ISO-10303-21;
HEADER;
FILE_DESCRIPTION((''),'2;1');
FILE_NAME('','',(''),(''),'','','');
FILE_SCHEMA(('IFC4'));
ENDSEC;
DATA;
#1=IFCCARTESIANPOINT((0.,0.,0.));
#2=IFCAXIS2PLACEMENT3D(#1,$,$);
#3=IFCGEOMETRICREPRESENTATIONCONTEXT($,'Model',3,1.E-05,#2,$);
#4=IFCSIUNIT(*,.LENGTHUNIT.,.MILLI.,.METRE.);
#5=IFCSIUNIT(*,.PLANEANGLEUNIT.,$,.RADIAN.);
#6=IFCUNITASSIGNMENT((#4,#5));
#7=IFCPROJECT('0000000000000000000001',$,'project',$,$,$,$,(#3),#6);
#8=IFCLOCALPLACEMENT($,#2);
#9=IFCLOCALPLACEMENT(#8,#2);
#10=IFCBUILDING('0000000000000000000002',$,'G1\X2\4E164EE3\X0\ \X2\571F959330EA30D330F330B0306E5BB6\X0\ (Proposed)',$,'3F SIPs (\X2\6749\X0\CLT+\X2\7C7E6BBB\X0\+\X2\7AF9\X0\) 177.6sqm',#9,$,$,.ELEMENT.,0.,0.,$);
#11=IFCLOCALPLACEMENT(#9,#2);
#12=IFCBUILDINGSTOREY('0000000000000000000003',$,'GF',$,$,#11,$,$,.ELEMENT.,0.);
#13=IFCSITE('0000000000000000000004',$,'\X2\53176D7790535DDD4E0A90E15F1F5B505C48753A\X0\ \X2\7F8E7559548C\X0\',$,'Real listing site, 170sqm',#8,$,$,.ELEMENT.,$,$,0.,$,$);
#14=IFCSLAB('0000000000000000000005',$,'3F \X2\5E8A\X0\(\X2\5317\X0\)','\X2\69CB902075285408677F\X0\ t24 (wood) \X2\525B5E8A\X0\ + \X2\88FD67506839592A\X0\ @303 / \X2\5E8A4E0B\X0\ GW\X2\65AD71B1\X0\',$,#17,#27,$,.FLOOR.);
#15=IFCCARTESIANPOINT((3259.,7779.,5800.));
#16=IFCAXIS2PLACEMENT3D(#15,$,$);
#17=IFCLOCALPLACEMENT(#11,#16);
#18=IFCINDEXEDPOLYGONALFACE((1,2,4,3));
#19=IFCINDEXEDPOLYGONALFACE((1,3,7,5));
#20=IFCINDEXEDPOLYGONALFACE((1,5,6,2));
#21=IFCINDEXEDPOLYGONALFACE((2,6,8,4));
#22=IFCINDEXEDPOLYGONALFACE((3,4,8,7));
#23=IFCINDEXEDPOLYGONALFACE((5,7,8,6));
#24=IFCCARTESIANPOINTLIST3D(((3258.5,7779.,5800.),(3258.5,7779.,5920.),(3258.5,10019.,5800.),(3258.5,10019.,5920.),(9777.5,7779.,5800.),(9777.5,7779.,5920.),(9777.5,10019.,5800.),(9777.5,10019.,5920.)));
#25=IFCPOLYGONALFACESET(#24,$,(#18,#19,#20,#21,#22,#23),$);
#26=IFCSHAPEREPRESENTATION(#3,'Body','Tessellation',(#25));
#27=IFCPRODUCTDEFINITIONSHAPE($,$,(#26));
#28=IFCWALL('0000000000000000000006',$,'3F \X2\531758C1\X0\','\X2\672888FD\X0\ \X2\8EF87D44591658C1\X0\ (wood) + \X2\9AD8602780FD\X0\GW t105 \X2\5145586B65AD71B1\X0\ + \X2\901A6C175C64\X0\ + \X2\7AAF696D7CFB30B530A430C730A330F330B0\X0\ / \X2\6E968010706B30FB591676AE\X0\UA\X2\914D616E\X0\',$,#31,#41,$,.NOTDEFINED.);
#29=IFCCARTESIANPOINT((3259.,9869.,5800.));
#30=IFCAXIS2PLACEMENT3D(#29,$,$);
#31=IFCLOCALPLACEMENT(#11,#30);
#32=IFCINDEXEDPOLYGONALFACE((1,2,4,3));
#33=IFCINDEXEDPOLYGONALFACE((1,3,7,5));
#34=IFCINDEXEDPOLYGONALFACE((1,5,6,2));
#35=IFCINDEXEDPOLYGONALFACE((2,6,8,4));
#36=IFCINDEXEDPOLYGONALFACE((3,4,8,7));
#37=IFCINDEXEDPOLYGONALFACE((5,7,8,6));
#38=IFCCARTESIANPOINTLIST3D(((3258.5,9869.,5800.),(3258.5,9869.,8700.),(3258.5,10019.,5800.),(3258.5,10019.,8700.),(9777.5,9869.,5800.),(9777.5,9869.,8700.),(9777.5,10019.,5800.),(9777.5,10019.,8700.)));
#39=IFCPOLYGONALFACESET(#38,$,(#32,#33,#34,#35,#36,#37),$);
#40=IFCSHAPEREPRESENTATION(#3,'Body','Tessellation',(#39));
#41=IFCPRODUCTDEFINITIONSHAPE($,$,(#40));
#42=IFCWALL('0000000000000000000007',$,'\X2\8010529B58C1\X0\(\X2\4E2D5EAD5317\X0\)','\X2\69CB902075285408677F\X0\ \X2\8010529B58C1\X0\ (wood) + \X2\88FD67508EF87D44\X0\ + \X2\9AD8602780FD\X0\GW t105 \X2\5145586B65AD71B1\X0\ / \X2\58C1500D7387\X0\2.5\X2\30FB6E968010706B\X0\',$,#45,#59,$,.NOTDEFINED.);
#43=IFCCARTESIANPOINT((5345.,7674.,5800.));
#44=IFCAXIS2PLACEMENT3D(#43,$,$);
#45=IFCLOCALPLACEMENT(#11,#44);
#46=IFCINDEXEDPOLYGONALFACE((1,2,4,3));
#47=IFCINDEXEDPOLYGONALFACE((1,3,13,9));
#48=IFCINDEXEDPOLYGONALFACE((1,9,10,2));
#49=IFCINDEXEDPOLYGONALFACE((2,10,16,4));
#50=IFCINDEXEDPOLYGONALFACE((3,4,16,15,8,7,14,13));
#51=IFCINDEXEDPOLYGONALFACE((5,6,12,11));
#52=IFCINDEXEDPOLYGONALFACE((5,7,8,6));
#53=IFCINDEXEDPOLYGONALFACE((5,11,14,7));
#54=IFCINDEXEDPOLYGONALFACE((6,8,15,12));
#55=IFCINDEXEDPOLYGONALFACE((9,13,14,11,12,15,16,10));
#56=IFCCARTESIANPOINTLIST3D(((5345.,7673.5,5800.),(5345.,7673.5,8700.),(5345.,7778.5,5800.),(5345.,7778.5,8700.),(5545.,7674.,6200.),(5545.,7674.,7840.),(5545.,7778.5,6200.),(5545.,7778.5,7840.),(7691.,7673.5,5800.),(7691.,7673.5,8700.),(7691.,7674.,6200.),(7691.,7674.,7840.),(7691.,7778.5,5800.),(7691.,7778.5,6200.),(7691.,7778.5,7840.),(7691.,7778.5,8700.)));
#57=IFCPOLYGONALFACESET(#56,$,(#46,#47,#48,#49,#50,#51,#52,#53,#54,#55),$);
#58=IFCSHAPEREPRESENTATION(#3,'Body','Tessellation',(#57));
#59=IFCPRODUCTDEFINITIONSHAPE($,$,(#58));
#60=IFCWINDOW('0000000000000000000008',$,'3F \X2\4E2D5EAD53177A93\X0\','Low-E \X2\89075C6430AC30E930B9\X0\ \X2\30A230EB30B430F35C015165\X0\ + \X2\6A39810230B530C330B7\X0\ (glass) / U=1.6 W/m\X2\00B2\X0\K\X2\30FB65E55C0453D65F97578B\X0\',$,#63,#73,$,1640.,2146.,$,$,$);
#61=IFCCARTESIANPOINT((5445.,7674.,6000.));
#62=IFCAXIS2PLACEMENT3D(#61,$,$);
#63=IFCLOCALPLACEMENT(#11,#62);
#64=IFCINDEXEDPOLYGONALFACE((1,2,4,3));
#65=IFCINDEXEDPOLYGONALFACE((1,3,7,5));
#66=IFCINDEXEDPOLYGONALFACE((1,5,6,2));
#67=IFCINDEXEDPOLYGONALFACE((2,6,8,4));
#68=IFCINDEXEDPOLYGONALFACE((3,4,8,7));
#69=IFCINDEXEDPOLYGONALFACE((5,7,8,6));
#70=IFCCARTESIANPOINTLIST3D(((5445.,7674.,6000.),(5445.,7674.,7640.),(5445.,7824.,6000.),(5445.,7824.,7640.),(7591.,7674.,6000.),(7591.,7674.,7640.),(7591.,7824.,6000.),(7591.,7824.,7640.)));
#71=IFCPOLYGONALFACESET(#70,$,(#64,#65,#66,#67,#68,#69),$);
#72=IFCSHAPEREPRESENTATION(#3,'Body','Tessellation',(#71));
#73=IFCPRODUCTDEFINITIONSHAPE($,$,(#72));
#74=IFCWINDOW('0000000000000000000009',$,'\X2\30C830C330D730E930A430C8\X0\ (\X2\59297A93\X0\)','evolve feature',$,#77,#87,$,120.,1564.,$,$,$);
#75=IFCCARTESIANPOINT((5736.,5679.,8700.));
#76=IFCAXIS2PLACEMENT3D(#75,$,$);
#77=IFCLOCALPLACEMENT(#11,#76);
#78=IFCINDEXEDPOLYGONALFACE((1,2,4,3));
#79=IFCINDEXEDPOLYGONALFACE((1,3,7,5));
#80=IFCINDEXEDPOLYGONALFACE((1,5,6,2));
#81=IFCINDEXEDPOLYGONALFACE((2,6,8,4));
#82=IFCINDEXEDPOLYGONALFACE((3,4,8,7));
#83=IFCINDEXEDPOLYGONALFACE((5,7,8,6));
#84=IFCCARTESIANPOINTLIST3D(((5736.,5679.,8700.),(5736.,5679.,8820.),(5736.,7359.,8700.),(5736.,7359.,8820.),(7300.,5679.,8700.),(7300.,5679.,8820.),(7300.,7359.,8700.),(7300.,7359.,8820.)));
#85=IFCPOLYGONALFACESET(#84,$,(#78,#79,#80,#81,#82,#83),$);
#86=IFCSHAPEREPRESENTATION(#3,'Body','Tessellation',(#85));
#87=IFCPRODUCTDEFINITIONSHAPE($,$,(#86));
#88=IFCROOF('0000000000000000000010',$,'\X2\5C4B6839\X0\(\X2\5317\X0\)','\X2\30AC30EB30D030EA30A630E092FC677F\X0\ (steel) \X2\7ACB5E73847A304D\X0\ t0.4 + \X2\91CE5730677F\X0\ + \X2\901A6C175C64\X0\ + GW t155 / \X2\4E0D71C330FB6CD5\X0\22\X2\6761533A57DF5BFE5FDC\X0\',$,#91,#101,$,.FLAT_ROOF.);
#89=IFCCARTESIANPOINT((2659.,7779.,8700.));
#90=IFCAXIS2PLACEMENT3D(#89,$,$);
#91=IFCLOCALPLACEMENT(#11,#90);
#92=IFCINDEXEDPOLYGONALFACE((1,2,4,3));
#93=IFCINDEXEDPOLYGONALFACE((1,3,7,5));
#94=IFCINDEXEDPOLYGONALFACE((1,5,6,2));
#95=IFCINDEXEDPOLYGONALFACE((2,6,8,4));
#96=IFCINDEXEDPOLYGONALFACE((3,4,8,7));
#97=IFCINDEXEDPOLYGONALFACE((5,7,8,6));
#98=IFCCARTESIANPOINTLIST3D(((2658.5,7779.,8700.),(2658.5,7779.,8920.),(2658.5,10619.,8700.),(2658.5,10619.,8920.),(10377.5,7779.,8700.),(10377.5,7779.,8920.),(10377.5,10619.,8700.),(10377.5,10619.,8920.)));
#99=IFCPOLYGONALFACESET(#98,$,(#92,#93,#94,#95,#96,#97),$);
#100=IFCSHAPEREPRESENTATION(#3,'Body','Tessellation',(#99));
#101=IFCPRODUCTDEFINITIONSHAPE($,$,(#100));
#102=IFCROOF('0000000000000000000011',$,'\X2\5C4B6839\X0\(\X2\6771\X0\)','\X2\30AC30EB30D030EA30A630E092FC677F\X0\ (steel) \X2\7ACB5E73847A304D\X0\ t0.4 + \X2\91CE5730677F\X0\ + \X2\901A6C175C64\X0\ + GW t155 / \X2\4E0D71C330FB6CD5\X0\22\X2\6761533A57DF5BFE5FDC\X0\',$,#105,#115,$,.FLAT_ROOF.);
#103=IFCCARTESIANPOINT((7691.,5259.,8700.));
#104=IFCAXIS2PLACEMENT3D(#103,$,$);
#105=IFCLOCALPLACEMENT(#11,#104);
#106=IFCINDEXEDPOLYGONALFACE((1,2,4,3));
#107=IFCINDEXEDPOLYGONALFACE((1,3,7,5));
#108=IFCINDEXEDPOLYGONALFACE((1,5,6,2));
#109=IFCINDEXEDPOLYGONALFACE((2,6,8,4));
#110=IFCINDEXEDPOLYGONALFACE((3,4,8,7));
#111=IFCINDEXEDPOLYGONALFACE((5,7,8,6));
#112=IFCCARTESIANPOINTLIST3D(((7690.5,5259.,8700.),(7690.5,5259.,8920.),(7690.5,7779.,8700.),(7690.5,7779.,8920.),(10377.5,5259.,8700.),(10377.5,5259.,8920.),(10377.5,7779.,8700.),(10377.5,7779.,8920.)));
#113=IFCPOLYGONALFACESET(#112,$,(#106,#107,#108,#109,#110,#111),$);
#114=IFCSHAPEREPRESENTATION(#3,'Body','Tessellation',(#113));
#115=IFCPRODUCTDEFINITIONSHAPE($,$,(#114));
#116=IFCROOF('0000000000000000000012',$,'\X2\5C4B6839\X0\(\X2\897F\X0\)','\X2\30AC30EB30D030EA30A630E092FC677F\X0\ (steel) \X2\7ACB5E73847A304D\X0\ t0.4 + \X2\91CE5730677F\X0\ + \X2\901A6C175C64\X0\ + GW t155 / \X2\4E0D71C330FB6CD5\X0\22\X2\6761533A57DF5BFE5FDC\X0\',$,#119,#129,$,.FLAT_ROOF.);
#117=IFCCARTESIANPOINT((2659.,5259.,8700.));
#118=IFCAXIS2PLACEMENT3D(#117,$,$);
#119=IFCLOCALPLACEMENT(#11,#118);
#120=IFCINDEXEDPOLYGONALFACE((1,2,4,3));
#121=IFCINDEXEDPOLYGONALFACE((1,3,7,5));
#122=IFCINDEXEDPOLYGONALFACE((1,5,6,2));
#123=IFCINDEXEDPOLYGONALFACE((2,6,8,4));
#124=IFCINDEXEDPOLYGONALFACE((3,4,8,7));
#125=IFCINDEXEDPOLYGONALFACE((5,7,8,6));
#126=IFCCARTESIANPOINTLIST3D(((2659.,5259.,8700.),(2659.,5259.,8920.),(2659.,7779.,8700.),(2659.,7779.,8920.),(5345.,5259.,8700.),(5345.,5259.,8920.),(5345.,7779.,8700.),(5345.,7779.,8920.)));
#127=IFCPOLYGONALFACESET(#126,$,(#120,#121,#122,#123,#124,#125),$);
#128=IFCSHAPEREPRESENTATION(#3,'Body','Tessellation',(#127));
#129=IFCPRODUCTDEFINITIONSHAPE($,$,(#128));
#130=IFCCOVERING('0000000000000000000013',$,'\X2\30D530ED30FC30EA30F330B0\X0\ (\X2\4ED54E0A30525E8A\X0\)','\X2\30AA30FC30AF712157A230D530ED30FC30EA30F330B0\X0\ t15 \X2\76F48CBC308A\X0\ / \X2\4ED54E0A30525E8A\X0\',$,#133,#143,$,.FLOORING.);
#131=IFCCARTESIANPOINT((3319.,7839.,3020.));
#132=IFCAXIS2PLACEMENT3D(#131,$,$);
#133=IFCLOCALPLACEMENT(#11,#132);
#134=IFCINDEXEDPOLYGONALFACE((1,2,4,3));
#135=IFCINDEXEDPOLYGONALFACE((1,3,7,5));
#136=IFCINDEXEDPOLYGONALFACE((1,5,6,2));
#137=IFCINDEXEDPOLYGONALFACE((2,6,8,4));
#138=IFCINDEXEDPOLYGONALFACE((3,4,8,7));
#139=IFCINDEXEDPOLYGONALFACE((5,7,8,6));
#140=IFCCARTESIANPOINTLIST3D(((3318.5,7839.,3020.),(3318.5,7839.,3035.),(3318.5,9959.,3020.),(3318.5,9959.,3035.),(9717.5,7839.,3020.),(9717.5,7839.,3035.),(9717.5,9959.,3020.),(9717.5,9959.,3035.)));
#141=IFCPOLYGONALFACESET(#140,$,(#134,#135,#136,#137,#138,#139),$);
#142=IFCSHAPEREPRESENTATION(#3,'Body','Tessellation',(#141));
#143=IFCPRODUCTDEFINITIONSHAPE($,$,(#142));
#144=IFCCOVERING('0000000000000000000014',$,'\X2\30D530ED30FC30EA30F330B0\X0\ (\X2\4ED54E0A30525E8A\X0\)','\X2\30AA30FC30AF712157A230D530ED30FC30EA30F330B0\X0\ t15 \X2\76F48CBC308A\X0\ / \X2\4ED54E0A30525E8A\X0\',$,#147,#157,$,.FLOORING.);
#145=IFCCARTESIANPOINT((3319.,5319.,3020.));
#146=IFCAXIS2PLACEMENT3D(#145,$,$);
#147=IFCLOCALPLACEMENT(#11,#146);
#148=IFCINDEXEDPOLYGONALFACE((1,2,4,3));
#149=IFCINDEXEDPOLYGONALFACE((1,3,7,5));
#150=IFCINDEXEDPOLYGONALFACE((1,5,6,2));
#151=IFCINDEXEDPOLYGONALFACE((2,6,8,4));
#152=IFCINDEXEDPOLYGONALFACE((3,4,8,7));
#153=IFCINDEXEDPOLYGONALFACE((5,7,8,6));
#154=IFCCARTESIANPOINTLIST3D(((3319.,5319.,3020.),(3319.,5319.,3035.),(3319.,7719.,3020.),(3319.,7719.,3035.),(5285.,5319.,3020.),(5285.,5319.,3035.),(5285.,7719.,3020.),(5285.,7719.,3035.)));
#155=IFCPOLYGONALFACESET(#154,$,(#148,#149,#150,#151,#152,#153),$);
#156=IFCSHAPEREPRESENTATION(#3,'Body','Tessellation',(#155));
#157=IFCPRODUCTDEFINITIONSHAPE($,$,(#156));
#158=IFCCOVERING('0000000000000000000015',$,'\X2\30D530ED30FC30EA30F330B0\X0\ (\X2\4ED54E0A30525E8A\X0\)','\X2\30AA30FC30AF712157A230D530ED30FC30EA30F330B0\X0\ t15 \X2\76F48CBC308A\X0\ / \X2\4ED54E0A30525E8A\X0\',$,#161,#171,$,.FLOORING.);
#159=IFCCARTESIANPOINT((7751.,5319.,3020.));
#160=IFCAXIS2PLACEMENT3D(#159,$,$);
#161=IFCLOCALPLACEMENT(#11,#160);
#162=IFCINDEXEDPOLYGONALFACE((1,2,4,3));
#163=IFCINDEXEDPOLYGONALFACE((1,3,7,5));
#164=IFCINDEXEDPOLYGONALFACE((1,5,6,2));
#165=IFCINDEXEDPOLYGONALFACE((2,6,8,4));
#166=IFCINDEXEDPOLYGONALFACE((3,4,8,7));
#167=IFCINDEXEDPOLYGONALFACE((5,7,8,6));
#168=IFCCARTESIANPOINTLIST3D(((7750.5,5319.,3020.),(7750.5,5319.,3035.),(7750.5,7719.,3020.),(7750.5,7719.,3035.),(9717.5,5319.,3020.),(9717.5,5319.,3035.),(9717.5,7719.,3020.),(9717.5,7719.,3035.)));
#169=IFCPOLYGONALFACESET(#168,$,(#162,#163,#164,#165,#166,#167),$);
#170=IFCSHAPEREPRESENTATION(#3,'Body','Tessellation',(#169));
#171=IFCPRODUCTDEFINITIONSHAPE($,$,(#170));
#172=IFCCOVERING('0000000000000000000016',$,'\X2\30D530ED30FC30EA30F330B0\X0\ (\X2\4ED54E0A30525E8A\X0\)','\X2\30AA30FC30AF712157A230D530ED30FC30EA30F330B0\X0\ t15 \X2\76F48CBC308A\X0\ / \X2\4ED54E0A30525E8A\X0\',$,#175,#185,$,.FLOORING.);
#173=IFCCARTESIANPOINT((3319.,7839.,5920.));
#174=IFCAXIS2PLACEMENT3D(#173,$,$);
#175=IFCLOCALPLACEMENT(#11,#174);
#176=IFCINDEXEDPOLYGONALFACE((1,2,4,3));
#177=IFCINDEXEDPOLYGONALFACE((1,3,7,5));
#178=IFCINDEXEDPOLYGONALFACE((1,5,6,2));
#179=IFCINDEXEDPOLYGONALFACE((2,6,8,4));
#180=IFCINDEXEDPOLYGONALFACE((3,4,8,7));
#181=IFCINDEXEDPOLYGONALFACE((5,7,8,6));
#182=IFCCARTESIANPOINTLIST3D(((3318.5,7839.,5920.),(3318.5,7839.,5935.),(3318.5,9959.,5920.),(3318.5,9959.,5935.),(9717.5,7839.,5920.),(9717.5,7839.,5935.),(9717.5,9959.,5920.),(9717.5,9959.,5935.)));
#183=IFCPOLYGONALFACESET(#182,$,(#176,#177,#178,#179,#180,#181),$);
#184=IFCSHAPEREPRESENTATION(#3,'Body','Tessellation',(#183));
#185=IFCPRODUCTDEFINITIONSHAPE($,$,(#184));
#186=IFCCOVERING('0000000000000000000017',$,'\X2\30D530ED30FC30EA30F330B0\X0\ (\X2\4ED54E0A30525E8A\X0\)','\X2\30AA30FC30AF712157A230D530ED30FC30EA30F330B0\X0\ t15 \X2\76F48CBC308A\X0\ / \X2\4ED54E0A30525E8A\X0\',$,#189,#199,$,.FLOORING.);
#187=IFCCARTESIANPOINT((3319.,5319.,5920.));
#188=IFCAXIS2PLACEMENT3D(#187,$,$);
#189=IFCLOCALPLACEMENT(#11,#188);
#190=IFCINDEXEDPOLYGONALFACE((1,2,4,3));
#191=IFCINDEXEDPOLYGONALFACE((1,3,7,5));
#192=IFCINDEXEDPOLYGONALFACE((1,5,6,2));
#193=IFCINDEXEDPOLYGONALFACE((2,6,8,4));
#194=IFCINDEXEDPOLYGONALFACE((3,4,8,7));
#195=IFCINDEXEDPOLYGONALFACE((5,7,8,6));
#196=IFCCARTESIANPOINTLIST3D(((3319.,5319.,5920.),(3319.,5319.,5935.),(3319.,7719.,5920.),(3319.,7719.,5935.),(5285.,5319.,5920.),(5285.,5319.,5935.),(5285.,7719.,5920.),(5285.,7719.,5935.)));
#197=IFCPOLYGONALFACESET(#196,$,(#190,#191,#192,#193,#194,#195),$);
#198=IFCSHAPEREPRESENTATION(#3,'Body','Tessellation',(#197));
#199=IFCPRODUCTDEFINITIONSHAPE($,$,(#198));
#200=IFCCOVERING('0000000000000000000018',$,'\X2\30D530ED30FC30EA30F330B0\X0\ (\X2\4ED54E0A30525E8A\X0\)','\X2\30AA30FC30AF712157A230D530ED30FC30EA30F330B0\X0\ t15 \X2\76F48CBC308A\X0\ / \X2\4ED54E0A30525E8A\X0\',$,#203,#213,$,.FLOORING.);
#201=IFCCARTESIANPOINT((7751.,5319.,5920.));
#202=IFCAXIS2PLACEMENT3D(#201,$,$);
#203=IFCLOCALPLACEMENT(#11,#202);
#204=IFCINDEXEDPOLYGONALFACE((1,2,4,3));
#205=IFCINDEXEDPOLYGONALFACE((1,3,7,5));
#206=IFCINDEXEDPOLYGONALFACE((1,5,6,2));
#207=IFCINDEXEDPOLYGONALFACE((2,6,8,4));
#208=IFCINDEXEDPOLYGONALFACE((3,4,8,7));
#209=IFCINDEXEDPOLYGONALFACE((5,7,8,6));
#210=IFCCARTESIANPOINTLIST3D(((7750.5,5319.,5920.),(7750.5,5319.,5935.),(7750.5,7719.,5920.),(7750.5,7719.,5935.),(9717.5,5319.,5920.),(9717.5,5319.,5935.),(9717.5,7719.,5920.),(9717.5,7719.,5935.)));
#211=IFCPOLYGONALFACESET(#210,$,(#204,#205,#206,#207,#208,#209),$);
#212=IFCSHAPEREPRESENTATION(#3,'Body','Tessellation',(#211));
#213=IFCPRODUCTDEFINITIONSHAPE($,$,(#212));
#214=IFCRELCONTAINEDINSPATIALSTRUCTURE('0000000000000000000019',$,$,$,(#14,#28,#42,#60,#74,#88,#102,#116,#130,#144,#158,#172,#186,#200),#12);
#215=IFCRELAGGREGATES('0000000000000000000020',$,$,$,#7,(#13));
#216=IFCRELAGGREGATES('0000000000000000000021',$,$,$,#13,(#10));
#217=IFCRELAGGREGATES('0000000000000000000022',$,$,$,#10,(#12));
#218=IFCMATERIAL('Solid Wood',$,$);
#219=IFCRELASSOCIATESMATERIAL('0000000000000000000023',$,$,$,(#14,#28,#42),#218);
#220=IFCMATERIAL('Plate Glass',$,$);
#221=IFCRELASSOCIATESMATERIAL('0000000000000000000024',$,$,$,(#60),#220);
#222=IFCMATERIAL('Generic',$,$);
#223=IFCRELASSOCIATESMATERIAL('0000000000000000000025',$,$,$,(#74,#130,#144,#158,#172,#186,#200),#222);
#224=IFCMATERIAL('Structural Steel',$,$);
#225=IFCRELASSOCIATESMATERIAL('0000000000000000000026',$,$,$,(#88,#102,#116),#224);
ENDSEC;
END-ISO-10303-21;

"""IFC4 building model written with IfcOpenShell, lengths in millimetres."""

from ifc_helpers import new_model, si_unit, frame, frame_2d, origin, place, context, project, spatial, rectangle, extrude, material, element, fill, save


model = new_model("IFC4")

# Units and contexts
model_context = context("Model", 3, precision=1e-05, world=origin())
ifc_project = project(units=[si_unit("LENGTHUNIT", "METRE", prefix="MILLI"), si_unit("PLANEANGLEUNIT", "RADIAN")], contexts=[model_context])

# Site, building, storey
site_placement = place(None, origin())
site = spatial("IfcSite", under=ifc_project, at=site_placement, Name="北海道川上郡弟子屈町 美留和", ObjectType="Real listing site, 170sqm", CompositionType="ELEMENT", RefElevation=0.0)
building_placement = place(site_placement, origin())
building = spatial("IfcBuilding", under=site, at=building_placement, Name="G1世代 土間リビングの家 (Proposed)", ObjectType="3F SIPs (杉CLT+籾殻+竹) 177.6sqm", CompositionType="ELEMENT", ElevationOfRefHeight=0.0, ElevationOfTerrain=0.0)
storey_placement = place(building_placement, origin())
storey = spatial("IfcBuildingStorey", under=building, at=storey_placement, Name="GF", CompositionType="ELEMENT", Elevation=0.0)

# Slab
ifc_material_1 = material(Name="Solid Wood")
slab_placement = place(storey_placement, frame((3259.0, 7779.0, 5800.0)))
element("IfcSlab", 1, at=slab_placement, inside=storey, material=ifc_material_1, Name="3F 床(北)", Description="構造用合板 t24 (wood) 剛床 + 製材根太 @303 / 床下 GW断熱", PredefinedType="FLOOR", context=model_context, shape_type="SweptSolid", body=[
    extrude(rectangle(XDim=6519.0, YDim=2240.0, at=frame_2d((3259.0, 1120.0))), frame((3259.0, 7779.0, 5800.0)), (0.0, 0.0, 1.0), 120.0),
])

# Wall
wall_1_placement = place(storey_placement, frame((3259.0, 9869.0, 5800.0)))
element("IfcWall", 2, at=wall_1_placement, inside=storey, material=ifc_material_1, Name="3F 北壁", Description="木製 軸組外壁 (wood) + 高性能GW t105 充填断熱 + 通気層 + 窯業系サイディング / 準耐火・外皮UA配慮", PredefinedType="NOTDEFINED", context=model_context, shape_type="SweptSolid", body=[
    extrude(rectangle(XDim=6519.0, YDim=150.0, at=frame_2d((3259.0, 75.0))), frame((3259.0, 9869.0, 5800.0)), (0.0, 0.0, 1.0), 2900.0),
])

# Wall, opening, window
wall_2_placement = place(storey_placement, frame((5345.0, 7674.0, 5800.0)))
wall_2 = element("IfcWall", 3, at=wall_2_placement, inside=storey, material=ifc_material_1, Name="耐力壁(中庭北)", Description="構造用合板 耐力壁 (wood) + 製材軸組 + 高性能GW t105 充填断熱 / 壁倍率2.5・準耐火", PredefinedType="NOTDEFINED", context=model_context, shape_type="SweptSolid", body=[
    extrude(rectangle(XDim=2346.0, YDim=105.0, at=frame_2d((1173.0, 52.0))), frame((5345.0, 7674.0, 5800.0)), (0.0, 0.0, 1.0), 2900.0),
])
opening_placement = place(storey_placement, frame((5445.0, 7674.0, 6000.0)))
opening = element("IfcOpeningElement", 4, at=opening_placement, cuts=wall_2, PredefinedType="NOTDEFINED", context=model_context, shape_type="SweptSolid", body=[
    extrude(rectangle(XDim=2146.0, YDim=150.0, at=frame_2d((1073.0, 75.0))), frame((5445.0, 7674.0, 6000.0)), (0.0, 0.0, 1.0), 1640.0),
])
ifc_material_2 = material(Name="Plate Glass")
window_1_placement = place(storey_placement, frame((5445.0, 7674.0, 6000.0)))
window_1 = element("IfcWindow", 5, at=window_1_placement, inside=storey, material=ifc_material_2, Name="3F 中庭北窓", Description="Low-E 複層ガラス アルゴン封入 + 樹脂サッシ (glass) / U=1.6 W/m²K・日射取得型", OverallHeight=1640.0, OverallWidth=2146.0, context=model_context, shape_type="SweptSolid", body=[
    extrude(rectangle(XDim=2146.0, YDim=150.0, at=frame_2d((1073.0, 75.0))), frame((5445.0, 7674.0, 6000.0)), (0.0, 0.0, 1.0), 1640.0),
])
fill(opening, window_1)

# Window
ifc_material_3 = material(Name="Generic")
window_2_placement = place(storey_placement, frame((5736.0, 5679.0, 8700.0)))
element("IfcWindow", 6, at=window_2_placement, inside=storey, material=ifc_material_3, Name="トップライト (天窓)", Description="evolve feature", OverallHeight=120.0, OverallWidth=1564.0, context=model_context, shape_type="SweptSolid", body=[
    extrude(rectangle(XDim=1564.0, YDim=1680.0, at=frame_2d((782.0, 840.0))), frame((5736.0, 5679.0, 8700.0)), (0.0, 0.0, 1.0), 120.0),
])

# Roofs
ifc_material_4 = material(Name="Structural Steel")
roof_1_placement = place(storey_placement, frame((2659.0, 7779.0, 8700.0)))
element("IfcRoof", 7, at=roof_1_placement, inside=storey, material=ifc_material_4, Name="屋根(北)", Description="ガルバリウム鋼板 (steel) 立平葺き t0.4 + 野地板 + 通気層 + GW t155 / 不燃・法22条区域対応", PredefinedType="FLAT_ROOF", context=model_context, shape_type="SweptSolid", body=[
    extrude(rectangle(XDim=7719.0, YDim=2840.0, at=frame_2d((3859.0, 1420.0))), frame((2659.0, 7779.0, 8700.0)), (0.0, 0.0, 1.0), 220.0),
])
roof_2_placement = place(storey_placement, frame((7691.0, 5259.0, 8700.0)))
element("IfcRoof", 8, at=roof_2_placement, inside=storey, material=ifc_material_4, Name="屋根(東)", Description="ガルバリウム鋼板 (steel) 立平葺き t0.4 + 野地板 + 通気層 + GW t155 / 不燃・法22条区域対応", PredefinedType="FLAT_ROOF", context=model_context, shape_type="SweptSolid", body=[
    extrude(rectangle(XDim=2687.0, YDim=2520.0, at=frame_2d((1343.0, 1260.0))), frame((7691.0, 5259.0, 8700.0)), (0.0, 0.0, 1.0), 220.0),
])
roof_3_placement = place(storey_placement, frame((2659.0, 5259.0, 8700.0)))
element("IfcRoof", 9, at=roof_3_placement, inside=storey, material=ifc_material_4, Name="屋根(西)", Description="ガルバリウム鋼板 (steel) 立平葺き t0.4 + 野地板 + 通気層 + GW t155 / 不燃・法22条区域対応", PredefinedType="FLAT_ROOF", context=model_context, shape_type="SweptSolid", body=[
    extrude(rectangle(XDim=2686.0, YDim=2520.0, at=frame_2d((1343.0, 1260.0))), frame((2659.0, 5259.0, 8700.0)), (0.0, 0.0, 1.0), 220.0),
])

# Coverings
covering_1_placement = place(storey_placement, frame((3319.0, 7839.0, 3020.0)))
element("IfcCovering", 10, at=covering_1_placement, inside=storey, material=ifc_material_3, Name="フローリング (仕上げ床)", Description="オーク無垢フローリング t15 直貼り / 仕上げ床", PredefinedType="FLOORING", context=model_context, shape_type="SweptSolid", body=[
    extrude(rectangle(XDim=6399.0, YDim=2120.0, at=frame_2d((3199.0, 1060.0))), frame((3319.0, 7839.0, 3020.0)), (0.0, 0.0, 1.0), 15.0),
])
covering_2_placement = place(storey_placement, frame((3319.0, 5319.0, 3020.0)))
element("IfcCovering", 11, at=covering_2_placement, inside=storey, material=ifc_material_3, Name="フローリング (仕上げ床)", Description="オーク無垢フローリング t15 直貼り / 仕上げ床", PredefinedType="FLOORING", context=model_context, shape_type="SweptSolid", body=[
    extrude(rectangle(XDim=1966.0, YDim=2400.0, at=frame_2d((983.0, 1200.0))), frame((3319.0, 5319.0, 3020.0)), (0.0, 0.0, 1.0), 15.0),
])
covering_3_placement = place(storey_placement, frame((7751.0, 5319.0, 3020.0)))
element("IfcCovering", 12, at=covering_3_placement, inside=storey, material=ifc_material_3, Name="フローリング (仕上げ床)", Description="オーク無垢フローリング t15 直貼り / 仕上げ床", PredefinedType="FLOORING", context=model_context, shape_type="SweptSolid", body=[
    extrude(rectangle(XDim=1967.0, YDim=2400.0, at=frame_2d((983.0, 1200.0))), frame((7751.0, 5319.0, 3020.0)), (0.0, 0.0, 1.0), 15.0),
])
covering_4_placement = place(storey_placement, frame((3319.0, 7839.0, 5920.0)))
element("IfcCovering", 13, at=covering_4_placement, inside=storey, material=ifc_material_3, Name="フローリング (仕上げ床)", Description="オーク無垢フローリング t15 直貼り / 仕上げ床", PredefinedType="FLOORING", context=model_context, shape_type="SweptSolid", body=[
    extrude(rectangle(XDim=6399.0, YDim=2120.0, at=frame_2d((3199.0, 1060.0))), frame((3319.0, 7839.0, 5920.0)), (0.0, 0.0, 1.0), 15.0),
])
covering_5_placement = place(storey_placement, frame((3319.0, 5319.0, 5920.0)))
element("IfcCovering", 14, at=covering_5_placement, inside=storey, material=ifc_material_3, Name="フローリング (仕上げ床)", Description="オーク無垢フローリング t15 直貼り / 仕上げ床", PredefinedType="FLOORING", context=model_context, shape_type="SweptSolid", body=[
    extrude(rectangle(XDim=1966.0, YDim=2400.0, at=frame_2d((983.0, 1200.0))), frame((3319.0, 5319.0, 5920.0)), (0.0, 0.0, 1.0), 15.0),
])
covering_6_placement = place(storey_placement, frame((7751.0, 5319.0, 5920.0)))
element("IfcCovering", 15, at=covering_6_placement, inside=storey, material=ifc_material_3, Name="フローリング (仕上げ床)", Description="オーク無垢フローリング t15 直貼り / 仕上げ床", PredefinedType="FLOORING", context=model_context, shape_type="SweptSolid", body=[
    extrude(rectangle(XDim=1967.0, YDim=2400.0, at=frame_2d((983.0, 1200.0))), frame((7751.0, 5319.0, 5920.0)), (0.0, 0.0, 1.0), 15.0),
])

save(model, "model.ifc")
